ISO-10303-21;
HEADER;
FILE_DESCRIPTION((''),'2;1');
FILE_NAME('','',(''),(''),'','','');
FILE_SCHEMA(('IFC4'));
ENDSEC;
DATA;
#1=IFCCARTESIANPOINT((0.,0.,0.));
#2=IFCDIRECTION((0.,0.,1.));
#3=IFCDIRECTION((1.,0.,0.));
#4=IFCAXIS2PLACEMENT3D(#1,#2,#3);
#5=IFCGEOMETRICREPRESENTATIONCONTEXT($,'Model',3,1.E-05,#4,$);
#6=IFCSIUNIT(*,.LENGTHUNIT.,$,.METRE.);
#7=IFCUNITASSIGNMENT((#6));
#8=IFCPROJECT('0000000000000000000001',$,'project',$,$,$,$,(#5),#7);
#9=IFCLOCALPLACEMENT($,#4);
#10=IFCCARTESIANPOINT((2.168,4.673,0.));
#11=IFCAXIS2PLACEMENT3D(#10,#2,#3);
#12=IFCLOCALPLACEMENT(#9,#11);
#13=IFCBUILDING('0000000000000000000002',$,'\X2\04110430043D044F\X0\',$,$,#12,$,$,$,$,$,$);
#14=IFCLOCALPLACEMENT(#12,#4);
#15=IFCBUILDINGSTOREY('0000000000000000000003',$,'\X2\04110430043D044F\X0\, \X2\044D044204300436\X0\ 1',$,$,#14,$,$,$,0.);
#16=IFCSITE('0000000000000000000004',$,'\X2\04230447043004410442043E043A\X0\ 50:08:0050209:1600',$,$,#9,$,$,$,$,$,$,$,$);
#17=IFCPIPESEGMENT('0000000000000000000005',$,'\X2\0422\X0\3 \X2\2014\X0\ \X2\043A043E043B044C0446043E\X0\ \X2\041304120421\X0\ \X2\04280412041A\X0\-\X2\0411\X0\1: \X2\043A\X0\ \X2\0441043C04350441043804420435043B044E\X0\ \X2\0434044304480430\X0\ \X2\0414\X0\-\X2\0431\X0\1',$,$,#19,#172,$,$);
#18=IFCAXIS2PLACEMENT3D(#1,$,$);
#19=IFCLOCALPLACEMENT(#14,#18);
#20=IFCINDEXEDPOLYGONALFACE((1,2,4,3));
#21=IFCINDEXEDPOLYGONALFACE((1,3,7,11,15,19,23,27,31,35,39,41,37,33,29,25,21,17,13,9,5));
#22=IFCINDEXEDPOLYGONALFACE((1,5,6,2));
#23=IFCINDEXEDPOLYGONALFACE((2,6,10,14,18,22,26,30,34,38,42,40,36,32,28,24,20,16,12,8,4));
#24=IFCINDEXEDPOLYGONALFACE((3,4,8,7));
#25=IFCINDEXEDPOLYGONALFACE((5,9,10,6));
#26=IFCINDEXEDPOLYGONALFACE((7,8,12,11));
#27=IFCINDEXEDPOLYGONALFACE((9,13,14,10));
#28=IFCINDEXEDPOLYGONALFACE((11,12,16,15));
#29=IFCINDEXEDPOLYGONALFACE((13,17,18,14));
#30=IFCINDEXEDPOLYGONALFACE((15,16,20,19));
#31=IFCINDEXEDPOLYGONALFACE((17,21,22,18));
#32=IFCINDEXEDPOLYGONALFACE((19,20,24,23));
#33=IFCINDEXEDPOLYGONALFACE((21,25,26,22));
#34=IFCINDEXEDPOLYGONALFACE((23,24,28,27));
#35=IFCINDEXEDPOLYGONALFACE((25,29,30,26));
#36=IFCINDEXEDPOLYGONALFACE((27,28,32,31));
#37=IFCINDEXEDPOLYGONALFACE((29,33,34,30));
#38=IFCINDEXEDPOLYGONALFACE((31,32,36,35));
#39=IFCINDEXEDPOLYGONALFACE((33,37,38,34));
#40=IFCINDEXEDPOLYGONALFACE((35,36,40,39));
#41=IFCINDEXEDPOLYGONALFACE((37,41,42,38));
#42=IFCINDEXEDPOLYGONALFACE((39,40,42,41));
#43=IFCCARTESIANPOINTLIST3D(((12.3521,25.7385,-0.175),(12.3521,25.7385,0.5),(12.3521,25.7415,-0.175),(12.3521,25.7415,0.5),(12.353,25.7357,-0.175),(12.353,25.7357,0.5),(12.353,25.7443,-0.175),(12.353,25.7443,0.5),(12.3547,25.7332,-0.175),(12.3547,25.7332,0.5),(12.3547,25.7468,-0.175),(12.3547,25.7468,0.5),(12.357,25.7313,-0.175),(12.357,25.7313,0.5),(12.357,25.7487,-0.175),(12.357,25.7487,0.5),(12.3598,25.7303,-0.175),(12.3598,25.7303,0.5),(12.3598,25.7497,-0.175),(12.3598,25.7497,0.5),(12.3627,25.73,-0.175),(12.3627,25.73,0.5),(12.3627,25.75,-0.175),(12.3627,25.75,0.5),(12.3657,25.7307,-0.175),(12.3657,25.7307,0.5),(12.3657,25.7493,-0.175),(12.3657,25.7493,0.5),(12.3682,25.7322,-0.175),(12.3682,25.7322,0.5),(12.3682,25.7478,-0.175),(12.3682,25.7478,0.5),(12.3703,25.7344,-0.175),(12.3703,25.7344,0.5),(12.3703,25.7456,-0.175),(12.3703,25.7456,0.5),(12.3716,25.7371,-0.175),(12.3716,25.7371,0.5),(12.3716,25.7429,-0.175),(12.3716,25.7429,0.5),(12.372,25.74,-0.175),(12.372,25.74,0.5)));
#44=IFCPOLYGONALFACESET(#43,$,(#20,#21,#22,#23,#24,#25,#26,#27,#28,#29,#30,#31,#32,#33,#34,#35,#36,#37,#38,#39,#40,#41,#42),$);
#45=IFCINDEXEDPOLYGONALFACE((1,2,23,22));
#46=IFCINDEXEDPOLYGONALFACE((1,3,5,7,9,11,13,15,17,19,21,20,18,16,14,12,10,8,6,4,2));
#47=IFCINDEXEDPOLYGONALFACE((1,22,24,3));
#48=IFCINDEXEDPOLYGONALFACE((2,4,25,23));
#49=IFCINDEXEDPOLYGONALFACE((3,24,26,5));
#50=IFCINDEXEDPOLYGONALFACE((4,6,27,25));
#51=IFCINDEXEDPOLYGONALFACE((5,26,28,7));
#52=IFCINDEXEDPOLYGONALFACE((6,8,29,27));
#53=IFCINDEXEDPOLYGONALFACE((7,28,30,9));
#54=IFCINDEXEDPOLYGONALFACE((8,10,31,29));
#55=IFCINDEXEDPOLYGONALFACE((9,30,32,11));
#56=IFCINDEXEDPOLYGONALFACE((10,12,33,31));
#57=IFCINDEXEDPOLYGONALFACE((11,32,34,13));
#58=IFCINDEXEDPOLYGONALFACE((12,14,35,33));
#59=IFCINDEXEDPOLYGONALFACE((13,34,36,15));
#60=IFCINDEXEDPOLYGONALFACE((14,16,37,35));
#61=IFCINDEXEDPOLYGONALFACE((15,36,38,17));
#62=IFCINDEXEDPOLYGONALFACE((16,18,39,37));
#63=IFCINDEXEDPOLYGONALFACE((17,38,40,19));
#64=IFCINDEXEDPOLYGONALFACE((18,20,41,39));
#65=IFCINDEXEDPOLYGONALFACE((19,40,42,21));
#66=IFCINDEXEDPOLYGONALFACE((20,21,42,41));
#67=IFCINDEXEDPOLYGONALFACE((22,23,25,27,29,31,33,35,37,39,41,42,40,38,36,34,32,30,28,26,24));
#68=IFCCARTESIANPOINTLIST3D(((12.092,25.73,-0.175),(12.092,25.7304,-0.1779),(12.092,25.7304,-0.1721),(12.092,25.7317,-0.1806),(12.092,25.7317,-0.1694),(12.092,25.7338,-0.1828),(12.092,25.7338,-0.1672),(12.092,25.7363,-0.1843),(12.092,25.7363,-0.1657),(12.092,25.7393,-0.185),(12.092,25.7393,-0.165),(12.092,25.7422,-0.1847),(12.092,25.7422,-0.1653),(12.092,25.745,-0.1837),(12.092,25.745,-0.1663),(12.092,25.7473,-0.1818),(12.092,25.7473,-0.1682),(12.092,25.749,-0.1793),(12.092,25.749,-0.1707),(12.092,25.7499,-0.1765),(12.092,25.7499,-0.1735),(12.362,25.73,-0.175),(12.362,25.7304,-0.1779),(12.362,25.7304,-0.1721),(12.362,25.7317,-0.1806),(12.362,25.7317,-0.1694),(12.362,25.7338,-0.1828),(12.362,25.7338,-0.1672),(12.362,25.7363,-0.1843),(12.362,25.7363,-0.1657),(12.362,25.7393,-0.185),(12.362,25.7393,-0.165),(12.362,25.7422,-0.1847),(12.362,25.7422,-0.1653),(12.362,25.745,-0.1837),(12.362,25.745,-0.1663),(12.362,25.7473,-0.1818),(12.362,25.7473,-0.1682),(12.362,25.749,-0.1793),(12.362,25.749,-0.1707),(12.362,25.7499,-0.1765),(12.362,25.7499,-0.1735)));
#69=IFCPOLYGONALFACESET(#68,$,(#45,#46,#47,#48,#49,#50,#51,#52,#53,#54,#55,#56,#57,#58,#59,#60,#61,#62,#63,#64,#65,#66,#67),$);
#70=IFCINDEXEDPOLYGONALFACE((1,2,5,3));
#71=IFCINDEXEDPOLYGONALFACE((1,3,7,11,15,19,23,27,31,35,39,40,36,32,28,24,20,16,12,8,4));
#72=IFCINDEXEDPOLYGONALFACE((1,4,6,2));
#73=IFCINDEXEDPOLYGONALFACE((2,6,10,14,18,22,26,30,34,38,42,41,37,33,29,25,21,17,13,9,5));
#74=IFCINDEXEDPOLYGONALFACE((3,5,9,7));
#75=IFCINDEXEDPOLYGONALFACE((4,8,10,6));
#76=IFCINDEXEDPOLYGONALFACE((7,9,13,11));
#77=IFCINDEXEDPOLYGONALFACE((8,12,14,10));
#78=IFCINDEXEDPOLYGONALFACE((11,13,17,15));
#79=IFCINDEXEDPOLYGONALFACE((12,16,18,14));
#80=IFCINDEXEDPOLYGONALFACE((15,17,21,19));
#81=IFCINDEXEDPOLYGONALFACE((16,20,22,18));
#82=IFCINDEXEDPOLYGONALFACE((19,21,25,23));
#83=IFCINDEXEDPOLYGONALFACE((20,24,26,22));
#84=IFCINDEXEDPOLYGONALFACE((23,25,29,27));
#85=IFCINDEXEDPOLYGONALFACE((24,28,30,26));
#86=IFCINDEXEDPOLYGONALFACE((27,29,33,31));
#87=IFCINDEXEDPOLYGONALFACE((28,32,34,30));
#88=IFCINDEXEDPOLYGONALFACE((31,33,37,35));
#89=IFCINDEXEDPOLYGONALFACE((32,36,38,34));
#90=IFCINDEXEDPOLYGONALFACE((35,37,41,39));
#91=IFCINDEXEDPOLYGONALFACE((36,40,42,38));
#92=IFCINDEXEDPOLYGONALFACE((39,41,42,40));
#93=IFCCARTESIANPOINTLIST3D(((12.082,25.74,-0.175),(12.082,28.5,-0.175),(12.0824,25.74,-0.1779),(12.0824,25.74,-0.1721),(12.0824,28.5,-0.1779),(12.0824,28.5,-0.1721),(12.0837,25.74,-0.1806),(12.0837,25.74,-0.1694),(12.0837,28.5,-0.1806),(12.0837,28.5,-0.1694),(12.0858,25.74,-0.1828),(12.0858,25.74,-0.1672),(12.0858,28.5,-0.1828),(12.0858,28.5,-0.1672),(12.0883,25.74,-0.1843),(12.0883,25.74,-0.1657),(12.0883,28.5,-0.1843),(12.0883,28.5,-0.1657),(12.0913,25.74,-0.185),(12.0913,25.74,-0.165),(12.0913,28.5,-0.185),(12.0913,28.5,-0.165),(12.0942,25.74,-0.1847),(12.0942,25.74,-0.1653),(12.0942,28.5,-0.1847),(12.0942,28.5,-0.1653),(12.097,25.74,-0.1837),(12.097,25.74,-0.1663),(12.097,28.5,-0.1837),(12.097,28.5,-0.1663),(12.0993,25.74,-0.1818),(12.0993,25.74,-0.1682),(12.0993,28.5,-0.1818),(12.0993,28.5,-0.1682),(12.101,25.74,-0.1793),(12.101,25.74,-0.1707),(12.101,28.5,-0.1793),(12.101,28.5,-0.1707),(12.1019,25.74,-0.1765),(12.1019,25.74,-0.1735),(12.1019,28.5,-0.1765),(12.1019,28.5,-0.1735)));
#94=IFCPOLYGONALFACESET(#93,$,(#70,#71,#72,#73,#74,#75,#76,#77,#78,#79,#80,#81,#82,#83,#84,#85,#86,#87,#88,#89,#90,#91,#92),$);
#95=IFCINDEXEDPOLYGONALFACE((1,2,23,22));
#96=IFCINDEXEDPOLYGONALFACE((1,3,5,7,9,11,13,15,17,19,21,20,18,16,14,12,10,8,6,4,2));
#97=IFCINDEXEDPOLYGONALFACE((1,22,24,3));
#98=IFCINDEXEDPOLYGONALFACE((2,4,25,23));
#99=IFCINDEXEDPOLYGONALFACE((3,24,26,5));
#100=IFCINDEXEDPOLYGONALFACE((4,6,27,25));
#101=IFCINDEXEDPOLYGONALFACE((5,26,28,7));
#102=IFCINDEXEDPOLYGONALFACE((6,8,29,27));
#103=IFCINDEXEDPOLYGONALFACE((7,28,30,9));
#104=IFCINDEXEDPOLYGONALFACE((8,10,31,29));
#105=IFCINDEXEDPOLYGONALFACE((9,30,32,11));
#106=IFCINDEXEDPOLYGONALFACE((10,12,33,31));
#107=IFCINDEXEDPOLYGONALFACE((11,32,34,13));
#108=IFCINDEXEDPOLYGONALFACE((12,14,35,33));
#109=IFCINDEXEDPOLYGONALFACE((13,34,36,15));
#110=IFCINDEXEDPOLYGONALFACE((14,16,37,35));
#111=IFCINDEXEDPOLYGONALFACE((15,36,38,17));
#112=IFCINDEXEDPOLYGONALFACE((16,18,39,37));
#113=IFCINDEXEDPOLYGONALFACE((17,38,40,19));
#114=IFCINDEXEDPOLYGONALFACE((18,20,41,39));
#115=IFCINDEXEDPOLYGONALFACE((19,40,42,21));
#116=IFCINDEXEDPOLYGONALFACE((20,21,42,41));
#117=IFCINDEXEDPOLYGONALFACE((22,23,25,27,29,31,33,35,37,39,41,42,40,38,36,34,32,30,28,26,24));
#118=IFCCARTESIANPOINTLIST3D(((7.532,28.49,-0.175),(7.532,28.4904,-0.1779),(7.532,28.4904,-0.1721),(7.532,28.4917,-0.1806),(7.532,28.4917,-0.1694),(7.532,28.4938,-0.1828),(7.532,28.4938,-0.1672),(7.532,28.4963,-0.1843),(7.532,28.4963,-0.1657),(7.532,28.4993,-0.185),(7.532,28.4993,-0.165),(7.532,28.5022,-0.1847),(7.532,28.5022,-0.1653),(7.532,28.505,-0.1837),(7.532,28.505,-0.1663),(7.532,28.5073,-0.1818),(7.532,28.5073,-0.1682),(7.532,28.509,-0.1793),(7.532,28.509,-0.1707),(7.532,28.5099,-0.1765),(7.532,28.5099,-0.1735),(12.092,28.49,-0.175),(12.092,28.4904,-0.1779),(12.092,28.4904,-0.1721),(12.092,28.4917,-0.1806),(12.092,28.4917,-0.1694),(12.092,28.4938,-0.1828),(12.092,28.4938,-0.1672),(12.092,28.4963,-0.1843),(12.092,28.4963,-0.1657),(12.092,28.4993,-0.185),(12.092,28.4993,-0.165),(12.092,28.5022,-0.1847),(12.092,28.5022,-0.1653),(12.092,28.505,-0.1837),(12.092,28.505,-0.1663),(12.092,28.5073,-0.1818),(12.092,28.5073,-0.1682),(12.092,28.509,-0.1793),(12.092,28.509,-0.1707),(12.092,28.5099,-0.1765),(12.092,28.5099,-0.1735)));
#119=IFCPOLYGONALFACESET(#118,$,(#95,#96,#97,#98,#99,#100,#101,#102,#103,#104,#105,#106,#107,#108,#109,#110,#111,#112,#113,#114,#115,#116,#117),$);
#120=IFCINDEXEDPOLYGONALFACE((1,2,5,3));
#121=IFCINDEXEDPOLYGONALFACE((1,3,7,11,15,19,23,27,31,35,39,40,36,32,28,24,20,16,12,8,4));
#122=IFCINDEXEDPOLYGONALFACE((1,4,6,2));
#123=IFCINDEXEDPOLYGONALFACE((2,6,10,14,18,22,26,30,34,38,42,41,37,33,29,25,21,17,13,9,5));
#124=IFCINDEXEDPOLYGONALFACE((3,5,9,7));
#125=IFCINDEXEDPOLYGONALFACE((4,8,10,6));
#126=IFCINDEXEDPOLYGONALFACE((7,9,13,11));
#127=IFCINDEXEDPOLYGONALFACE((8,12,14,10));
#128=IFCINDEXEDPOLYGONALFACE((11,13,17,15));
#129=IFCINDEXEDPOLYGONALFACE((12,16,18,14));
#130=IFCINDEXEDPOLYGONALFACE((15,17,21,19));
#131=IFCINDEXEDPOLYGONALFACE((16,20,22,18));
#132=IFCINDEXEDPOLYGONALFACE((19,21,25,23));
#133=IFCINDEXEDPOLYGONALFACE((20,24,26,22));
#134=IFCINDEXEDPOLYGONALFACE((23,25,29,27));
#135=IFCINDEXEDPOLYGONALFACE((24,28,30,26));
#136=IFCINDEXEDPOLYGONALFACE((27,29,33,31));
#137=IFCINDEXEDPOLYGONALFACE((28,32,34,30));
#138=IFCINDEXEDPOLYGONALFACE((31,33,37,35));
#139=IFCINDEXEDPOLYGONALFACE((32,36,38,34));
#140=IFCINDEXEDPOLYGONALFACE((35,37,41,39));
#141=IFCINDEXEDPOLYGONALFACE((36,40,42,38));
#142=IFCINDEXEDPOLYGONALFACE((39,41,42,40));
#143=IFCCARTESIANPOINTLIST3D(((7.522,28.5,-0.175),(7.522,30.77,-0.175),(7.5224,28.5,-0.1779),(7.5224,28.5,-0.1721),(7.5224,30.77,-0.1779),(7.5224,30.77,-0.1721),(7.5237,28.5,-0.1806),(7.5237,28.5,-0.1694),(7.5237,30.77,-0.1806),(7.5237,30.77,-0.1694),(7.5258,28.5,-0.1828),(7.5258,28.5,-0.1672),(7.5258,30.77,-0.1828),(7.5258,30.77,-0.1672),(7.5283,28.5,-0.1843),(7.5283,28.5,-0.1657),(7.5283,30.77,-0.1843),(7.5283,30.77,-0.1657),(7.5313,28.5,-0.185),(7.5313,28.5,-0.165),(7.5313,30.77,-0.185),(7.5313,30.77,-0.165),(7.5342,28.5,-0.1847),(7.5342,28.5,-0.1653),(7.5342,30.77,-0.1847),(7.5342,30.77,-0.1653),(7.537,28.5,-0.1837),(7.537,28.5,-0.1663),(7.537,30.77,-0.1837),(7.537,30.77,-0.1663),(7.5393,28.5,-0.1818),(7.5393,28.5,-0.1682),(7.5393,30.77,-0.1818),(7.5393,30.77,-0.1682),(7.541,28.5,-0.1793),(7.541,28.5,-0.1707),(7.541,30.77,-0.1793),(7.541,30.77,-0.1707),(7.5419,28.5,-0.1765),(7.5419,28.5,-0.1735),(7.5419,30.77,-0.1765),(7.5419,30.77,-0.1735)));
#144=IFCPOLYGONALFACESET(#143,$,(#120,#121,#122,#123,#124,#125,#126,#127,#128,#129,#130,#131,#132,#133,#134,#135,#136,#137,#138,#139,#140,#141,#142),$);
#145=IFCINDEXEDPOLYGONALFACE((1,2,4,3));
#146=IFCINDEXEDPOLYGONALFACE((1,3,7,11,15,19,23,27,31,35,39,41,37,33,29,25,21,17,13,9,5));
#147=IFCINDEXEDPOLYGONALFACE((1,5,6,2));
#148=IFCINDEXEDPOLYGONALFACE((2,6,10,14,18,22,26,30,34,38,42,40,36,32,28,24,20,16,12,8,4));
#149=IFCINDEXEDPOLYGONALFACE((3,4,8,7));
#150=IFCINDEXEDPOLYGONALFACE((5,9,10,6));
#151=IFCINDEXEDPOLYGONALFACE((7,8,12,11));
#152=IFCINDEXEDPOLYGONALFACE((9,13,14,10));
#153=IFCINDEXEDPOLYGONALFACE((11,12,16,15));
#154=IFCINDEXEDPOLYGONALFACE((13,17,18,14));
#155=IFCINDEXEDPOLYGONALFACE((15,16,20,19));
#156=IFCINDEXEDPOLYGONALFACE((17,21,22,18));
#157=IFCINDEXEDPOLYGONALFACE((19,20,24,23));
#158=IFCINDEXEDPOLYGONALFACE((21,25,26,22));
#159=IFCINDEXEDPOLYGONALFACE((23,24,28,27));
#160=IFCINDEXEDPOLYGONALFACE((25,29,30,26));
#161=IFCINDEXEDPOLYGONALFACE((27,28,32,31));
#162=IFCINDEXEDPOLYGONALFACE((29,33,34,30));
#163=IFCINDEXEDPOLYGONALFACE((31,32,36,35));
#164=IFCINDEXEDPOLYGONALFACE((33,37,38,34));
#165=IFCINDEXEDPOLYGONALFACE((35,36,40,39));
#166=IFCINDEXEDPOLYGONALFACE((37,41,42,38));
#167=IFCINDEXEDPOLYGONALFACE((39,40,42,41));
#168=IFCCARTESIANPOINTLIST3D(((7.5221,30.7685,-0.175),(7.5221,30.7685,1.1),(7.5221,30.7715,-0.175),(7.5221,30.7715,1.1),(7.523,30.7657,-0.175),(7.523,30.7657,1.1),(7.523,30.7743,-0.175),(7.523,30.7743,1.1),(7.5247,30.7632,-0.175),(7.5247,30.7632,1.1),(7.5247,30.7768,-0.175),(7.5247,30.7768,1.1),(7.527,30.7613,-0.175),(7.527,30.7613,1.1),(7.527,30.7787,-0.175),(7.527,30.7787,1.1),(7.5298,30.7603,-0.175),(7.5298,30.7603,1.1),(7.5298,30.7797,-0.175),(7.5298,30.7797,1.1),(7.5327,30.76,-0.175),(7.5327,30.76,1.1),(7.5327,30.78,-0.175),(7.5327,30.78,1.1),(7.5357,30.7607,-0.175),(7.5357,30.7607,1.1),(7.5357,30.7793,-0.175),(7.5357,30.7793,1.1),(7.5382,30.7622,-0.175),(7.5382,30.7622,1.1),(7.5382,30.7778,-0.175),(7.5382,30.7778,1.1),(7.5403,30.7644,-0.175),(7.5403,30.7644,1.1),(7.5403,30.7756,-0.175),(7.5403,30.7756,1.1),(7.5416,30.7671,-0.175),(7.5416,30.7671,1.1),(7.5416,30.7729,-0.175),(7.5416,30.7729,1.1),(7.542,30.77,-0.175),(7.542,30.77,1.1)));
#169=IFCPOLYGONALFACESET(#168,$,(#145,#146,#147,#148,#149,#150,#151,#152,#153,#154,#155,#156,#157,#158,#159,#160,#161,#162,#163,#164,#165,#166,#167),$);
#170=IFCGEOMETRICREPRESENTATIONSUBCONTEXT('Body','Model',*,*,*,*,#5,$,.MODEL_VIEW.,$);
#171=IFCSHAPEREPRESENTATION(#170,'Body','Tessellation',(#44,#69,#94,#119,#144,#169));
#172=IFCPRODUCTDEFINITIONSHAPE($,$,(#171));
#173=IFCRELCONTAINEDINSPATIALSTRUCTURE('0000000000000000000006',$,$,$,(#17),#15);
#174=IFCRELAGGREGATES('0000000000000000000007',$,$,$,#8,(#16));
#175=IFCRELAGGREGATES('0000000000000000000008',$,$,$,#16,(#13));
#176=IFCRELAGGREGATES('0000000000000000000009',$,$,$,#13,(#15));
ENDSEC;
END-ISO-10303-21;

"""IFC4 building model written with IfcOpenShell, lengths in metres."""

from ifc_helpers import new_model, si_unit, frame, origin_with_axes, origin_2d, place, context, subcontext, project, spatial, circle, extrude, element, save


model = new_model("IFC4")

# Units and contexts
model_context = context("Model", 3, precision=1e-05, world=origin_with_axes())
body_context = subcontext(model_context, "Body", "Model", "MODEL_VIEW")
ifc_project = project(units=[si_unit("LENGTHUNIT", "METRE")], contexts=[model_context])

# Site, building, storey
site_placement = place(None, origin_with_axes())
site = spatial("IfcSite", under=ifc_project, at=site_placement, Name="Участок 50:08:0050209:1600")
building_placement = place(site_placement, frame((2.168, 4.673, 0.0), z_axis=(0.0, 0.0, 1.0), x_axis=(1.0, 0.0, 0.0)))
building = spatial("IfcBuilding", under=site, at=building_placement, Name="Баня")
storey_placement = place(building_placement, origin_with_axes())
storey = spatial("IfcBuildingStorey", under=building, at=storey_placement, Name="Баня, этаж 1", Elevation=0.0)

# Pipe segment
pipe_segment_1_placement = place(storey_placement, origin_with_axes())
element("IfcPipeSegment", 1, at=pipe_segment_1_placement, inside=storey, Name="Т3 — кольцо ГВС ШВК-Б1: к смесителю душа Д-б1", context=body_context, shape_type="SweptSolid", body=[
    extrude(circle(Radius=0.01, at=origin_2d()), frame((12.362, 25.74, 0.5), z_axis=(0.0, 0.0, -1.0), x_axis=(1.0, 0.0, 0.0)), (0.0, 0.0, 1.0), 0.675),
    extrude(circle(Radius=0.01, at=origin_2d()), frame((12.362, 25.74, -0.175), z_axis=(-1.0, 0.0, 0.0), x_axis=(0.0, -1.0, 0.0)), (0.0, 0.0, 1.0), 0.27),
    extrude(circle(Radius=0.01, at=origin_2d()), frame((12.092, 25.74, -0.175), z_axis=(0.0, 1.0, 0.0), x_axis=(-1.0, 0.0, 0.0)), (0.0, 0.0, 1.0), 2.76),
    extrude(circle(Radius=0.01, at=origin_2d()), frame((12.092, 28.5, -0.175), z_axis=(-1.0, 0.0, 0.0), x_axis=(0.0, -1.0, 0.0)), (0.0, 0.0, 1.0), 4.56),
    extrude(circle(Radius=0.01, at=origin_2d()), frame((7.532, 28.5, -0.175), z_axis=(0.0, 1.0, 0.0), x_axis=(-1.0, 0.0, 0.0)), (0.0, 0.0, 1.0), 2.27),
    extrude(circle(Radius=0.01, at=origin_2d()), frame((7.532, 30.77, -0.175), z_axis=(0.0, 0.0, 1.0), x_axis=(1.0, 0.0, 0.0)), (0.0, 0.0, 1.0), 1.275),
])

save(model, "model.ifc")
